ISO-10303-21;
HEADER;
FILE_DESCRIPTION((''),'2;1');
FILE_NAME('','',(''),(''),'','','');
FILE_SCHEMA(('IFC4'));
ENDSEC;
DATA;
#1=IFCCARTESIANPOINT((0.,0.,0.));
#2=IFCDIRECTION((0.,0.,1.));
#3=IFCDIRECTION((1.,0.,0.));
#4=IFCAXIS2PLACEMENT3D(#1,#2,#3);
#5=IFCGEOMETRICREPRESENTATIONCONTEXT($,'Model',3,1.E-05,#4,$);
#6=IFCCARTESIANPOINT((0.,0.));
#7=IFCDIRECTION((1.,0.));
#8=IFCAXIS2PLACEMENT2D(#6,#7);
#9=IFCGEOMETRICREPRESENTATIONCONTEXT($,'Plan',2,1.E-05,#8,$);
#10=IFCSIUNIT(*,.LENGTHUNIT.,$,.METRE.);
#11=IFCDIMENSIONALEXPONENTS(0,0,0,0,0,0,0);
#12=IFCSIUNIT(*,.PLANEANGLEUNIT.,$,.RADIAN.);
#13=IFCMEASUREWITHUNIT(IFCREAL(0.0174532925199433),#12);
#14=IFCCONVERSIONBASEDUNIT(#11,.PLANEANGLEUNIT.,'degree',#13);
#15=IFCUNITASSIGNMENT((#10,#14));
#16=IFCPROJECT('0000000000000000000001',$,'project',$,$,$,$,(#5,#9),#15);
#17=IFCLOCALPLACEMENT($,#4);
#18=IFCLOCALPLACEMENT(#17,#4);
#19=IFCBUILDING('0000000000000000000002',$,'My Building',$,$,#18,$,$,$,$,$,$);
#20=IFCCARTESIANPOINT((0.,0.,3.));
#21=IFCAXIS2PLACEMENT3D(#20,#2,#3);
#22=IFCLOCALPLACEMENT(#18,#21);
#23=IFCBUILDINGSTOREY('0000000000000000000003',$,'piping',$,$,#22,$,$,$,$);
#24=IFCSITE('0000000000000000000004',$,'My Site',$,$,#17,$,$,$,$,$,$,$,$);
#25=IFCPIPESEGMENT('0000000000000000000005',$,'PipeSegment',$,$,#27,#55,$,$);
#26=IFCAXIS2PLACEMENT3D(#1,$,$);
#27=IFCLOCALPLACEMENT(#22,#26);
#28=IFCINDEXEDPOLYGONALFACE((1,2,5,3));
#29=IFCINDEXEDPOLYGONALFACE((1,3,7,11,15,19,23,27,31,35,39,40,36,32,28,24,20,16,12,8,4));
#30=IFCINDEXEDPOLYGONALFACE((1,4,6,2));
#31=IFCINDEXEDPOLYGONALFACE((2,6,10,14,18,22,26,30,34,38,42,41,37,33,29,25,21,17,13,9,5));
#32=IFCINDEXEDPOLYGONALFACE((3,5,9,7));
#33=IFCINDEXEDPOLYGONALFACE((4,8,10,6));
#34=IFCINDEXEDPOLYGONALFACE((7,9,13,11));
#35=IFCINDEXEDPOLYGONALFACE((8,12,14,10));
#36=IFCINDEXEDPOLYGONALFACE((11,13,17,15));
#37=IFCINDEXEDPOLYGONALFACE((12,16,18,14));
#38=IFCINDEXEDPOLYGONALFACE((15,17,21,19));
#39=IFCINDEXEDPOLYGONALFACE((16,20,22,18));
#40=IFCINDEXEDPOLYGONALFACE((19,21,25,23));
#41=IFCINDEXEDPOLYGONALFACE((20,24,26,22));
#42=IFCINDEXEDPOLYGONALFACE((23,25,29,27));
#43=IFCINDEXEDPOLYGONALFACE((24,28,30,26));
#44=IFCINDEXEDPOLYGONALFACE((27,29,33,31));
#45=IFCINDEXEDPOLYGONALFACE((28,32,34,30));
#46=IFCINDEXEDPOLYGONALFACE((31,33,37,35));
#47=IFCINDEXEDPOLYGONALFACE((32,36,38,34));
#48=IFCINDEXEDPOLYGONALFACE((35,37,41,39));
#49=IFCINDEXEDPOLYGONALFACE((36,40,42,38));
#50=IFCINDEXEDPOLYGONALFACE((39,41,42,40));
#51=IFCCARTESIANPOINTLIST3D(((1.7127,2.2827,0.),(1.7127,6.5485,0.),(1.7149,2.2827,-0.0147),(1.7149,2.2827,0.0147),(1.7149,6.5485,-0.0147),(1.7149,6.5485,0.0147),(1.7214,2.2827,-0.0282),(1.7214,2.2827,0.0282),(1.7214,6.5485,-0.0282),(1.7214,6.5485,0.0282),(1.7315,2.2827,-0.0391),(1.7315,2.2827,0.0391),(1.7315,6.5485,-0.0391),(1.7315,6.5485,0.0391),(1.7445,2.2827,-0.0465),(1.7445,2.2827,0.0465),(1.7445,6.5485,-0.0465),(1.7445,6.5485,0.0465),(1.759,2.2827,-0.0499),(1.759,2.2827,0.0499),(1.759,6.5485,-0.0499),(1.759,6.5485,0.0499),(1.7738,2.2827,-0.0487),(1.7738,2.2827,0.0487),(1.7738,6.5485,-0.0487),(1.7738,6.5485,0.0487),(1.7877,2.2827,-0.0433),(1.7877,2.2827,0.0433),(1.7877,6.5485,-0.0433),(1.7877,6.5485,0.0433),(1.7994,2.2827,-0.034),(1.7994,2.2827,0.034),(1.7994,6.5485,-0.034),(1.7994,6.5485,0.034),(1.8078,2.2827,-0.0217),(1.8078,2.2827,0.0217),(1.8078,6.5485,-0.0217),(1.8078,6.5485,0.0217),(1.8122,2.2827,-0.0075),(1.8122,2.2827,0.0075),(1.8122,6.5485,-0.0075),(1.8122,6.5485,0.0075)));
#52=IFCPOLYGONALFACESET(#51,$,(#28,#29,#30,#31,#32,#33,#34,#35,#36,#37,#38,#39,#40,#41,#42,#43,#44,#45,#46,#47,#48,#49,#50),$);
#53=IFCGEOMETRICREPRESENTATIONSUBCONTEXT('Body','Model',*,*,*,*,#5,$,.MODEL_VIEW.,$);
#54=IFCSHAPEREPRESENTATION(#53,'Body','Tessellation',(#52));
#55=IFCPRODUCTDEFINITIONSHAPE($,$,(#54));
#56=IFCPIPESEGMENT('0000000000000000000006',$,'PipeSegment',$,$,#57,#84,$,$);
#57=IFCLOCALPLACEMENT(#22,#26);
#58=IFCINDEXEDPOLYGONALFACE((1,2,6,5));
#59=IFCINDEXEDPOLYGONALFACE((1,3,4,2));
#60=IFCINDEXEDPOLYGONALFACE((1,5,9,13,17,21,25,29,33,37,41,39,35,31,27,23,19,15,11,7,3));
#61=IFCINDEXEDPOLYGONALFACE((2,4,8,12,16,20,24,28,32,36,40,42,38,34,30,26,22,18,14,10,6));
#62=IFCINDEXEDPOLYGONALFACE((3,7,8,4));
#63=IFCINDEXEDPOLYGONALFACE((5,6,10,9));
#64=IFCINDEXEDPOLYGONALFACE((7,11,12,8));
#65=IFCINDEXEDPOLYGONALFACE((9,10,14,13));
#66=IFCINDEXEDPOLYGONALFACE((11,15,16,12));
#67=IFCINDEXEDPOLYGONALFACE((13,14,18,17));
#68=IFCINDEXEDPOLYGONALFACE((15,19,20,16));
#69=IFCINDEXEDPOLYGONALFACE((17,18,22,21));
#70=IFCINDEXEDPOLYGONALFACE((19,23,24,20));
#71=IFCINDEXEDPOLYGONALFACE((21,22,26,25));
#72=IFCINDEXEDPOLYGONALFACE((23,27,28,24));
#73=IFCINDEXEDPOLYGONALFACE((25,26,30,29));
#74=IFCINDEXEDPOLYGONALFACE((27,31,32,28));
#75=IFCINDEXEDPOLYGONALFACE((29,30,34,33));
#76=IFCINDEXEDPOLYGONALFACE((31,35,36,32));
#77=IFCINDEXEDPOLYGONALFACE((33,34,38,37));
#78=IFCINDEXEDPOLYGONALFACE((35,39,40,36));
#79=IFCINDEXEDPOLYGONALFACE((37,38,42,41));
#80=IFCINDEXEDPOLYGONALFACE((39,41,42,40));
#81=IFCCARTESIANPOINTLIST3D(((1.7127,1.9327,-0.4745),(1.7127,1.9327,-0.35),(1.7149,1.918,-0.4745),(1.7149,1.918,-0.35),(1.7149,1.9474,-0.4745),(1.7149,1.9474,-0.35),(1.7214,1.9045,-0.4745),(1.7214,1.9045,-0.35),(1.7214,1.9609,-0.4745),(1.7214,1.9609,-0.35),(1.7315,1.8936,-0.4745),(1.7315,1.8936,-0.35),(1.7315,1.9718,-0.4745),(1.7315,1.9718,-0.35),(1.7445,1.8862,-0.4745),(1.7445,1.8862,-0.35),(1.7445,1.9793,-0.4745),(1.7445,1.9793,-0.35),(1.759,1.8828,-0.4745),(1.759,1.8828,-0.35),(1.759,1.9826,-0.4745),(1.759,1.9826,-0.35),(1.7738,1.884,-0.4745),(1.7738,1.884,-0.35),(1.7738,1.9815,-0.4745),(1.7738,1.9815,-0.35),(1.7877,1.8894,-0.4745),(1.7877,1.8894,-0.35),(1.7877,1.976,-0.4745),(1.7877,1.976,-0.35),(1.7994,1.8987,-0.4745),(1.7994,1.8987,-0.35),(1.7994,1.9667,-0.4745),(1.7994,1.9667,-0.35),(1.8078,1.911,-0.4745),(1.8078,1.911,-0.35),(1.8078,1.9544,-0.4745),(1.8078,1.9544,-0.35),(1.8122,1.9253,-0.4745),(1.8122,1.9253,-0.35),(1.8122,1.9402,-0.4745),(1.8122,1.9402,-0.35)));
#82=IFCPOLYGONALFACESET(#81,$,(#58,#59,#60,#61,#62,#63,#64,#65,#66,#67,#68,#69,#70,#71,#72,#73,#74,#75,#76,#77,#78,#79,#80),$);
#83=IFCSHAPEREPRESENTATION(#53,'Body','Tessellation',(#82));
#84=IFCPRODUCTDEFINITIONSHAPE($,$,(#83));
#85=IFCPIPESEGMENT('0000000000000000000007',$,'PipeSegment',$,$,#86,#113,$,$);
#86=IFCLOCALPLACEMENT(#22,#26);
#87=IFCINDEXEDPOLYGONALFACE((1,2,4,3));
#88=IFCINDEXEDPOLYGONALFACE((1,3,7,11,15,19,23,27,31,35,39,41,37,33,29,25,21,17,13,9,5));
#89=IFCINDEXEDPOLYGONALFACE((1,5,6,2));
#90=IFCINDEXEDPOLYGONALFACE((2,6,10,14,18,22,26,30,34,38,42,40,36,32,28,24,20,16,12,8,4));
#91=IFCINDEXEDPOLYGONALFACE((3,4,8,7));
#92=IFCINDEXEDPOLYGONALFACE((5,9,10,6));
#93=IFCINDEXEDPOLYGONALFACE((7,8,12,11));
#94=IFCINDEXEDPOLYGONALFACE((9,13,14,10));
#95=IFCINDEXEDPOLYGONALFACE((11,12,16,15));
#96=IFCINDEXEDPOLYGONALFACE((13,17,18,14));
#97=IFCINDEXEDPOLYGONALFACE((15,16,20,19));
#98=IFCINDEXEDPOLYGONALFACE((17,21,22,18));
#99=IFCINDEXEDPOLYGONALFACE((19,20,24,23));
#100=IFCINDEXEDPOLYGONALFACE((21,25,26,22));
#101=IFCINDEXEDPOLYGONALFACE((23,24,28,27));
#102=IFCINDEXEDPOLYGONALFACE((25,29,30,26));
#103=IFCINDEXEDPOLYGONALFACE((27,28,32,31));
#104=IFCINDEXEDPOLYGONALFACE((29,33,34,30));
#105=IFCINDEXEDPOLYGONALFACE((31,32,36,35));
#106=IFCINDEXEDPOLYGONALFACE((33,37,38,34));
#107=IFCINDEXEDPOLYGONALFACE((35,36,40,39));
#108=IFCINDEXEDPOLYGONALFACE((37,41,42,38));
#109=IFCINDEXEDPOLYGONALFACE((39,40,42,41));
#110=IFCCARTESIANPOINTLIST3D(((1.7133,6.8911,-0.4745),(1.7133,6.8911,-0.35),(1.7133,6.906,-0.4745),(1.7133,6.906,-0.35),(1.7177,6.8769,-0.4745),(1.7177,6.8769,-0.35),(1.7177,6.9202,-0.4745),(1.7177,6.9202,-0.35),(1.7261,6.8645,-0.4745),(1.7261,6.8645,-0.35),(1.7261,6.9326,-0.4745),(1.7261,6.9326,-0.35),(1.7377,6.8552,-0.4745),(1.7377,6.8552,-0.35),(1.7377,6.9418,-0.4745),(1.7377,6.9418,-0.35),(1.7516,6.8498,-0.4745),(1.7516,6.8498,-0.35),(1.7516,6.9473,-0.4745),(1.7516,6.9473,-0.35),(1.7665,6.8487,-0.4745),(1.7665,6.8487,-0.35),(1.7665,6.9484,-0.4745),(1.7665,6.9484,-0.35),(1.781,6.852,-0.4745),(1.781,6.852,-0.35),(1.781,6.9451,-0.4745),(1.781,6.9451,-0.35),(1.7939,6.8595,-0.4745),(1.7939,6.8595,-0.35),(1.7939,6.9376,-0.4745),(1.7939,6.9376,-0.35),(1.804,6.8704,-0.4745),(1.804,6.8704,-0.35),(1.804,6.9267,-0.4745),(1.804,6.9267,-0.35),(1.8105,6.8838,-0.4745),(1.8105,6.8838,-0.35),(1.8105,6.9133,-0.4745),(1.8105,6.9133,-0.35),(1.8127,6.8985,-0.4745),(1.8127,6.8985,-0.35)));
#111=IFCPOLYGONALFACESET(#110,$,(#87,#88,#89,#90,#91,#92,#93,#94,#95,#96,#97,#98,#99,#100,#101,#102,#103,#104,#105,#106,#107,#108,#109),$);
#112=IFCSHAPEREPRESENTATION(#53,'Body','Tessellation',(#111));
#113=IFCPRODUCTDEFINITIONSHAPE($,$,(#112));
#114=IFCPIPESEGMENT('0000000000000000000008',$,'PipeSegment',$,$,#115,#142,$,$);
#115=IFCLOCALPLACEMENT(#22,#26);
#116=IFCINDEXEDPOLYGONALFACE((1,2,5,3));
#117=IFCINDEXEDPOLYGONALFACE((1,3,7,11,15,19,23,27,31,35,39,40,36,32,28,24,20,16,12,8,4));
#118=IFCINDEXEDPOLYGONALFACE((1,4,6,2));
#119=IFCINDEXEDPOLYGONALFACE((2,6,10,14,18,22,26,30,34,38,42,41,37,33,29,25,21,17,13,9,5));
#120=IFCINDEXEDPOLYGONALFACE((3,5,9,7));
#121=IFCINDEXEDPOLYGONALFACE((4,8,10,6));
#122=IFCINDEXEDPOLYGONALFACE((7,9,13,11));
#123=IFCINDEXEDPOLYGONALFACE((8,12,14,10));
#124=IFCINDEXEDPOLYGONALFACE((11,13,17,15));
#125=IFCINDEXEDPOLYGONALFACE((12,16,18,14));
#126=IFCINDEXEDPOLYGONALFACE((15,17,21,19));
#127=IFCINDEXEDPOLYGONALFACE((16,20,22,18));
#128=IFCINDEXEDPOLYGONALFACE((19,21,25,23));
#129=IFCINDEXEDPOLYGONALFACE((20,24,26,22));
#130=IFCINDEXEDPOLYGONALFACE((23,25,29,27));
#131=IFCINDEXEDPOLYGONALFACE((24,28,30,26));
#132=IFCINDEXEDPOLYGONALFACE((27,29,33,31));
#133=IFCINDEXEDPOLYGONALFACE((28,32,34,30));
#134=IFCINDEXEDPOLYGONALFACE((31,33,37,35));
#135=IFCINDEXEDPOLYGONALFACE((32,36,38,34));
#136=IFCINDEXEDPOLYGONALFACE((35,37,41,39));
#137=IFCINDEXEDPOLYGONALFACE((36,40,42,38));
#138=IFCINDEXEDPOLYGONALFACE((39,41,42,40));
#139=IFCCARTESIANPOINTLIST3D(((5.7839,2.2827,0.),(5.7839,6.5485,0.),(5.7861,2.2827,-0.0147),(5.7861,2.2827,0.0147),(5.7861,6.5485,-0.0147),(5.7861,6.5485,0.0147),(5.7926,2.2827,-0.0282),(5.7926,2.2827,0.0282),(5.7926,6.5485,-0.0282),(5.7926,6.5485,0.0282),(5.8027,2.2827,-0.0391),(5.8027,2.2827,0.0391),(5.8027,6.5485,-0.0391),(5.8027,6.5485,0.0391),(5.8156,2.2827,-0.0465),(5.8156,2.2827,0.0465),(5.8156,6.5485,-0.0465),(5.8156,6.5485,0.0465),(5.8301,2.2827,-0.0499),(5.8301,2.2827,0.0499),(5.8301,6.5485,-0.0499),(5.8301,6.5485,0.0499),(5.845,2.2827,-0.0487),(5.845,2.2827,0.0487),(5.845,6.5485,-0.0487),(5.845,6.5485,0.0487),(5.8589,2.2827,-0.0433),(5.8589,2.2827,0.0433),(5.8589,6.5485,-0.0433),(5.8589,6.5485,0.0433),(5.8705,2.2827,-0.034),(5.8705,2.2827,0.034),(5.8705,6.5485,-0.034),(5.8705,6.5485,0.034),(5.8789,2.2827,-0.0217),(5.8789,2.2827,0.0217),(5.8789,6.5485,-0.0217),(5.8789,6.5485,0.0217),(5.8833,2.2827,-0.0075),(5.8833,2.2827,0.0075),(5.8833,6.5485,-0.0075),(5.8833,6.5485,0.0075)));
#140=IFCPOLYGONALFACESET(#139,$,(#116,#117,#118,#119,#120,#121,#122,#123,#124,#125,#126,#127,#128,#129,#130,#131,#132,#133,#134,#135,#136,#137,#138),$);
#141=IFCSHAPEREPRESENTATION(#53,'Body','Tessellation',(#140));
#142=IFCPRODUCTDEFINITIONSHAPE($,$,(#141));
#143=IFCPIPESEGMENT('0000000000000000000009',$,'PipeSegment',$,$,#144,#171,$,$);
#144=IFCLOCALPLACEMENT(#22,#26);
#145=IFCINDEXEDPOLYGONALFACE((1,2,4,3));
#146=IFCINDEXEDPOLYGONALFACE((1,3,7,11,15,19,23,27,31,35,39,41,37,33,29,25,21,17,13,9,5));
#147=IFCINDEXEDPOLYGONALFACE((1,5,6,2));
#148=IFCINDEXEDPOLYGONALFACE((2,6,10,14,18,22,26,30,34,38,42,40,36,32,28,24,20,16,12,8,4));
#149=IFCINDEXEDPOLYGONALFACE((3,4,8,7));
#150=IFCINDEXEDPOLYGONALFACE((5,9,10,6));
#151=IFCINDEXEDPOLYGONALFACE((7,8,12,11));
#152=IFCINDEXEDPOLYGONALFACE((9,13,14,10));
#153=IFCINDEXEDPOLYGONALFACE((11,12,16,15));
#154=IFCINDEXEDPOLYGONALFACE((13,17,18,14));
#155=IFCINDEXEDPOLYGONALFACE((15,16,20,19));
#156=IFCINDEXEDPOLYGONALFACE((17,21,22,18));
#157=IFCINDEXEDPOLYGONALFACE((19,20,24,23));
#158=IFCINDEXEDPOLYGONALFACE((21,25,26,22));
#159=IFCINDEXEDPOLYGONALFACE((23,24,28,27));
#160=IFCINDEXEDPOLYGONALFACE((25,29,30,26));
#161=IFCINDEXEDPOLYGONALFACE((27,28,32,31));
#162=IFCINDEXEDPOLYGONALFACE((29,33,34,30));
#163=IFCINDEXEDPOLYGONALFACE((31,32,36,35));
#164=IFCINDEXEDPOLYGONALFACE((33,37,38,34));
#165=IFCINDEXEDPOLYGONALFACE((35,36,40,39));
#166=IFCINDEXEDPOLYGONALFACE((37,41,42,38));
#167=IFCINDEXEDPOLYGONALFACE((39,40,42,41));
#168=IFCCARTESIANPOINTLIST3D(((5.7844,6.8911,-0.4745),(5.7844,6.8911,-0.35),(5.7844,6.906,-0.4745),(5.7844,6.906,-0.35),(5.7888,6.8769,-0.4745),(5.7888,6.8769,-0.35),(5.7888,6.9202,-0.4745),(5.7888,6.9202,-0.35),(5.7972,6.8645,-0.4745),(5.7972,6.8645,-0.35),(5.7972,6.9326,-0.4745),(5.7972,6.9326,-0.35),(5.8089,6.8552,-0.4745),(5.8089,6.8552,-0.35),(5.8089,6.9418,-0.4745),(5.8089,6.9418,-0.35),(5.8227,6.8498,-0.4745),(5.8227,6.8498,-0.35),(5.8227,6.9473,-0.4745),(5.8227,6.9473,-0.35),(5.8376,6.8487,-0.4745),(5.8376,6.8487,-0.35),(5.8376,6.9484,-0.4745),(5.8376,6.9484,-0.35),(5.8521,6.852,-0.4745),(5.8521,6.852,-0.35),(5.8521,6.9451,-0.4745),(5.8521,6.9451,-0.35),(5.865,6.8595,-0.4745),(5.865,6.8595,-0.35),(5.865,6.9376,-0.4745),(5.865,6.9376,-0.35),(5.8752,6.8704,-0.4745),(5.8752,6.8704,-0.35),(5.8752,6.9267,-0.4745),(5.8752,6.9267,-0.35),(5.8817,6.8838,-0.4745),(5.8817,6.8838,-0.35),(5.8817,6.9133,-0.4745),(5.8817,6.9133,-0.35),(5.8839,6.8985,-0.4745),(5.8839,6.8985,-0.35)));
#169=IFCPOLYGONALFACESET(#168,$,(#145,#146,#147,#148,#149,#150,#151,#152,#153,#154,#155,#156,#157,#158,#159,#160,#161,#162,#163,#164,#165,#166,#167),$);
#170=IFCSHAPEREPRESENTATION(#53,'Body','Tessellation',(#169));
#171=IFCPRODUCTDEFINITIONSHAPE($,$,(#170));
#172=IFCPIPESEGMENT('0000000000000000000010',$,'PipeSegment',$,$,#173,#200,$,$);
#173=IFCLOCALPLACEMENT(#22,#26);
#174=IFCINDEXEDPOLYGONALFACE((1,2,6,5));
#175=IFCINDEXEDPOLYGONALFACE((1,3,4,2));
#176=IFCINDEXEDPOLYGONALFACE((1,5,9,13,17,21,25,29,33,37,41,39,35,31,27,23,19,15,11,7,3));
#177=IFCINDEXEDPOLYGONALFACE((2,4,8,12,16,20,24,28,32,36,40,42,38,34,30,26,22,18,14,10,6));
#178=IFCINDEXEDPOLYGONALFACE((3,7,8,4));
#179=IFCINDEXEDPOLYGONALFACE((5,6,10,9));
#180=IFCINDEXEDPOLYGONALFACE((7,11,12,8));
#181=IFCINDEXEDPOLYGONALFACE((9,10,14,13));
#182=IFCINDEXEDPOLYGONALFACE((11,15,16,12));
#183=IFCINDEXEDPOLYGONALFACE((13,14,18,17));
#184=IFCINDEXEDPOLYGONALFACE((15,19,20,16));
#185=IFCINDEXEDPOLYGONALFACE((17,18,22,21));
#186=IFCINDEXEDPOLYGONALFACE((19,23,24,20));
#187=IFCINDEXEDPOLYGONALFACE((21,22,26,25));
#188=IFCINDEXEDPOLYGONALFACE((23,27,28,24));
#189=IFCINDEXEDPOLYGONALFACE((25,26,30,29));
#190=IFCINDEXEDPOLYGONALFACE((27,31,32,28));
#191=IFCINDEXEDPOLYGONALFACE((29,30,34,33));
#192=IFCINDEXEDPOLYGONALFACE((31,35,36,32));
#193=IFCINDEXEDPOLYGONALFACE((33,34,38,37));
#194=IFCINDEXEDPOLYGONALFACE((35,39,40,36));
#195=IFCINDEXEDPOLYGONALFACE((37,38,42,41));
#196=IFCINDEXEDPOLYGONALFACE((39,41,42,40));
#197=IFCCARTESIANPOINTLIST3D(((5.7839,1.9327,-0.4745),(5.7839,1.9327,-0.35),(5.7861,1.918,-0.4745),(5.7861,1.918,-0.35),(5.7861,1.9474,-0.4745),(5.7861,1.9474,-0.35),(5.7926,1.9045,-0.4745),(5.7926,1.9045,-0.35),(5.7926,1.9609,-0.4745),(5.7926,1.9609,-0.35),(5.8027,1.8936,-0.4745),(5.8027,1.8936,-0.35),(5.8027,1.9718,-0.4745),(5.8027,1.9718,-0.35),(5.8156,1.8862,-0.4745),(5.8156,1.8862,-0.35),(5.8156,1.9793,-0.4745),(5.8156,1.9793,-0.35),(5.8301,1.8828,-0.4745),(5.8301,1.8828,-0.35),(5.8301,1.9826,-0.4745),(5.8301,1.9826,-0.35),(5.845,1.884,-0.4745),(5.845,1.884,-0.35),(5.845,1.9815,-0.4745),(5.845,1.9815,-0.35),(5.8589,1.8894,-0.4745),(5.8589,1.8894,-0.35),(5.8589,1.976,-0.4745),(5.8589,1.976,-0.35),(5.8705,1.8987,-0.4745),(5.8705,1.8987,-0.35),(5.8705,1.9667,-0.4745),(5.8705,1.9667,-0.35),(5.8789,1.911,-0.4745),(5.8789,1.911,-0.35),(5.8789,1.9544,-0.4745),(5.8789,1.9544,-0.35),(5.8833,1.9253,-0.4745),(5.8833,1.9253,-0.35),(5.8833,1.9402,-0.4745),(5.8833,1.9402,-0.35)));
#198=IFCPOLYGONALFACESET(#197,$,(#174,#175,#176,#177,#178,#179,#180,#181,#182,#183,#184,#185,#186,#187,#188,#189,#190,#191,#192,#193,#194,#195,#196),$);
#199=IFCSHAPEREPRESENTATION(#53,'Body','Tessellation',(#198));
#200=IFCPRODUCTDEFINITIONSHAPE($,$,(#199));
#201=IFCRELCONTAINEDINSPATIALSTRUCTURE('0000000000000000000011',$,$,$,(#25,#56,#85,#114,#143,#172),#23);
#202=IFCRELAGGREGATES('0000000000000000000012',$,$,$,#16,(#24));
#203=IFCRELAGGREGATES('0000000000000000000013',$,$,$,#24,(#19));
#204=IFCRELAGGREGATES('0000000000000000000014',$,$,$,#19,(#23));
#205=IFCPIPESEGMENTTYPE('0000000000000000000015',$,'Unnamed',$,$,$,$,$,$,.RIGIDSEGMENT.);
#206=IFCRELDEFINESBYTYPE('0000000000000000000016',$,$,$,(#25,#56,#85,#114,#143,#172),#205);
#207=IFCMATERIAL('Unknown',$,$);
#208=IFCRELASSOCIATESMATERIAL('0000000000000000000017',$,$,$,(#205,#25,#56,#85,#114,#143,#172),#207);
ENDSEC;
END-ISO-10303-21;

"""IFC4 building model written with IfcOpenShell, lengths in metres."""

from ifc_helpers import new_model, entity, si_unit, converted_unit, frame, origin_with_axes, origin_2d_with_axis, place, context, subcontext, project, spatial, circle, extrude, material, material_profile, profile_set, profile_usage, type_object, element, save


model = new_model("IFC4")

# Units and contexts
model_context = context("Model", 3, precision=1e-05, world=origin_with_axes())
plan_context = context("Plan", 2, precision=1e-05, world=origin_2d_with_axis())
body_context = subcontext(model_context, "Body", "Model", "MODEL_VIEW")
ifc_project = project(units=[si_unit("LENGTHUNIT", "METRE"), converted_unit("PLANEANGLEUNIT", "degree", entity("IfcReal", 0.0174532925199433), si_unit("PLANEANGLEUNIT", "RADIAN"), dimensions=[0, 0, 0, 0, 0, 0, 0])], contexts=[model_context, plan_context])

# Site, building, storey
site_placement = place(None, origin_with_axes())
site = spatial("IfcSite", under=ifc_project, at=site_placement, Name="My Site")
building_placement = place(site_placement, origin_with_axes())
building = spatial("IfcBuilding", under=site, at=building_placement, Name="My Building")
storey_placement = place(building_placement, frame((0.0, 0.0, 3.0), z_axis=(0.0, 0.0, 1.0), x_axis=(1.0, 0.0, 0.0)))
storey = spatial("IfcBuildingStorey", under=building, at=storey_placement, Name="piping")

# Pipe segments
ifc_material = material(Name="Unknown")
ifc_material_profile = material_profile(ifc_material, circle(Radius=0.05))
ifc_profile_set = profile_set([ifc_material_profile])
ifc_profile_usage_1 = profile_usage(ifc_profile_set, cardinal=5)
pipe_segment_type = type_object("IfcPipeSegmentType", Name="Unnamed", PredefinedType="RIGIDSEGMENT", material=ifc_profile_set)
pipe_segment_1_placement = place(storey_placement, frame((1.7627, 2.2827, 0.0), z_axis=(0.0, 1.0, 0.0), x_axis=(-1.0, 0.0, 0.0)))
element("IfcPipeSegment", 1, at=pipe_segment_1_placement, inside=storey, type_object=pipe_segment_type, material=ifc_profile_usage_1, Name="PipeSegment", context=body_context, shape_type="SweptSolid", body=[
    extrude(circle(Radius=0.05), origin_with_axes(), (0.0, 0.0, 1.0), 4.2658),
])
ifc_profile_usage_2 = profile_usage(ifc_profile_set, cardinal=5)
pipe_segment_2_placement = place(storey_placement, frame((1.7627, 1.9327, -0.35), z_axis=(0.0, 0.0, -1.0), x_axis=(-1.0, 0.0, 0.0)))
element("IfcPipeSegment", 2, at=pipe_segment_2_placement, inside=storey, type_object=pipe_segment_type, material=ifc_profile_usage_2, Name="PipeSegment", context=body_context, shape_type="SweptSolid", body=[
    extrude(circle(Radius=0.05), origin_with_axes(), (0.0, 0.0, 1.0), 0.1245),
])
ifc_profile_usage_3 = profile_usage(ifc_profile_set, cardinal=5)
pipe_segment_3_placement = place(storey_placement, frame((1.7627, 6.8985, -0.35), z_axis=(0.0, 0.0, -1.0), x_axis=(1.0, 0.0, 0.0)))
element("IfcPipeSegment", 3, at=pipe_segment_3_placement, inside=storey, type_object=pipe_segment_type, material=ifc_profile_usage_3, Name="PipeSegment", context=body_context, shape_type="SweptSolid", body=[
    extrude(circle(Radius=0.05), origin_with_axes(), (0.0, 0.0, 1.0), 0.1245),
])
ifc_profile_usage_4 = profile_usage(ifc_profile_set, cardinal=5)
pipe_segment_4_placement = place(storey_placement, frame((5.8339, 2.2827, 0.0), z_axis=(0.0, 1.0, 0.0), x_axis=(-1.0, 0.0, 0.0)))
element("IfcPipeSegment", 4, at=pipe_segment_4_placement, inside=storey, type_object=pipe_segment_type, material=ifc_profile_usage_4, Name="PipeSegment", context=body_context, shape_type="SweptSolid", body=[
    extrude(circle(Radius=0.05), origin_with_axes(), (0.0, 0.0, 1.0), 4.2658),
])
ifc_profile_usage_5 = profile_usage(ifc_profile_set, cardinal=5)
pipe_segment_5_placement = place(storey_placement, frame((5.8339, 6.8985, -0.35), z_axis=(0.0, 0.0, -1.0), x_axis=(1.0, 0.0, 0.0)))
element("IfcPipeSegment", 5, at=pipe_segment_5_placement, inside=storey, type_object=pipe_segment_type, material=ifc_profile_usage_5, Name="PipeSegment", context=body_context, shape_type="SweptSolid", body=[
    extrude(circle(Radius=0.05), origin_with_axes(), (0.0, 0.0, 1.0), 0.1245),
])
ifc_profile_usage_6 = profile_usage(ifc_profile_set, cardinal=5)
pipe_segment_6_placement = place(storey_placement, frame((5.8339, 1.9327, -0.35), z_axis=(0.0, 0.0, -1.0), x_axis=(-1.0, 0.0, 0.0)))
element("IfcPipeSegment", 6, at=pipe_segment_6_placement, inside=storey, type_object=pipe_segment_type, material=ifc_profile_usage_6, Name="PipeSegment", context=body_context, shape_type="SweptSolid", body=[
    extrude(circle(Radius=0.05), origin_with_axes(), (0.0, 0.0, 1.0), 0.1245),
])

save(model, "model.ifc")
